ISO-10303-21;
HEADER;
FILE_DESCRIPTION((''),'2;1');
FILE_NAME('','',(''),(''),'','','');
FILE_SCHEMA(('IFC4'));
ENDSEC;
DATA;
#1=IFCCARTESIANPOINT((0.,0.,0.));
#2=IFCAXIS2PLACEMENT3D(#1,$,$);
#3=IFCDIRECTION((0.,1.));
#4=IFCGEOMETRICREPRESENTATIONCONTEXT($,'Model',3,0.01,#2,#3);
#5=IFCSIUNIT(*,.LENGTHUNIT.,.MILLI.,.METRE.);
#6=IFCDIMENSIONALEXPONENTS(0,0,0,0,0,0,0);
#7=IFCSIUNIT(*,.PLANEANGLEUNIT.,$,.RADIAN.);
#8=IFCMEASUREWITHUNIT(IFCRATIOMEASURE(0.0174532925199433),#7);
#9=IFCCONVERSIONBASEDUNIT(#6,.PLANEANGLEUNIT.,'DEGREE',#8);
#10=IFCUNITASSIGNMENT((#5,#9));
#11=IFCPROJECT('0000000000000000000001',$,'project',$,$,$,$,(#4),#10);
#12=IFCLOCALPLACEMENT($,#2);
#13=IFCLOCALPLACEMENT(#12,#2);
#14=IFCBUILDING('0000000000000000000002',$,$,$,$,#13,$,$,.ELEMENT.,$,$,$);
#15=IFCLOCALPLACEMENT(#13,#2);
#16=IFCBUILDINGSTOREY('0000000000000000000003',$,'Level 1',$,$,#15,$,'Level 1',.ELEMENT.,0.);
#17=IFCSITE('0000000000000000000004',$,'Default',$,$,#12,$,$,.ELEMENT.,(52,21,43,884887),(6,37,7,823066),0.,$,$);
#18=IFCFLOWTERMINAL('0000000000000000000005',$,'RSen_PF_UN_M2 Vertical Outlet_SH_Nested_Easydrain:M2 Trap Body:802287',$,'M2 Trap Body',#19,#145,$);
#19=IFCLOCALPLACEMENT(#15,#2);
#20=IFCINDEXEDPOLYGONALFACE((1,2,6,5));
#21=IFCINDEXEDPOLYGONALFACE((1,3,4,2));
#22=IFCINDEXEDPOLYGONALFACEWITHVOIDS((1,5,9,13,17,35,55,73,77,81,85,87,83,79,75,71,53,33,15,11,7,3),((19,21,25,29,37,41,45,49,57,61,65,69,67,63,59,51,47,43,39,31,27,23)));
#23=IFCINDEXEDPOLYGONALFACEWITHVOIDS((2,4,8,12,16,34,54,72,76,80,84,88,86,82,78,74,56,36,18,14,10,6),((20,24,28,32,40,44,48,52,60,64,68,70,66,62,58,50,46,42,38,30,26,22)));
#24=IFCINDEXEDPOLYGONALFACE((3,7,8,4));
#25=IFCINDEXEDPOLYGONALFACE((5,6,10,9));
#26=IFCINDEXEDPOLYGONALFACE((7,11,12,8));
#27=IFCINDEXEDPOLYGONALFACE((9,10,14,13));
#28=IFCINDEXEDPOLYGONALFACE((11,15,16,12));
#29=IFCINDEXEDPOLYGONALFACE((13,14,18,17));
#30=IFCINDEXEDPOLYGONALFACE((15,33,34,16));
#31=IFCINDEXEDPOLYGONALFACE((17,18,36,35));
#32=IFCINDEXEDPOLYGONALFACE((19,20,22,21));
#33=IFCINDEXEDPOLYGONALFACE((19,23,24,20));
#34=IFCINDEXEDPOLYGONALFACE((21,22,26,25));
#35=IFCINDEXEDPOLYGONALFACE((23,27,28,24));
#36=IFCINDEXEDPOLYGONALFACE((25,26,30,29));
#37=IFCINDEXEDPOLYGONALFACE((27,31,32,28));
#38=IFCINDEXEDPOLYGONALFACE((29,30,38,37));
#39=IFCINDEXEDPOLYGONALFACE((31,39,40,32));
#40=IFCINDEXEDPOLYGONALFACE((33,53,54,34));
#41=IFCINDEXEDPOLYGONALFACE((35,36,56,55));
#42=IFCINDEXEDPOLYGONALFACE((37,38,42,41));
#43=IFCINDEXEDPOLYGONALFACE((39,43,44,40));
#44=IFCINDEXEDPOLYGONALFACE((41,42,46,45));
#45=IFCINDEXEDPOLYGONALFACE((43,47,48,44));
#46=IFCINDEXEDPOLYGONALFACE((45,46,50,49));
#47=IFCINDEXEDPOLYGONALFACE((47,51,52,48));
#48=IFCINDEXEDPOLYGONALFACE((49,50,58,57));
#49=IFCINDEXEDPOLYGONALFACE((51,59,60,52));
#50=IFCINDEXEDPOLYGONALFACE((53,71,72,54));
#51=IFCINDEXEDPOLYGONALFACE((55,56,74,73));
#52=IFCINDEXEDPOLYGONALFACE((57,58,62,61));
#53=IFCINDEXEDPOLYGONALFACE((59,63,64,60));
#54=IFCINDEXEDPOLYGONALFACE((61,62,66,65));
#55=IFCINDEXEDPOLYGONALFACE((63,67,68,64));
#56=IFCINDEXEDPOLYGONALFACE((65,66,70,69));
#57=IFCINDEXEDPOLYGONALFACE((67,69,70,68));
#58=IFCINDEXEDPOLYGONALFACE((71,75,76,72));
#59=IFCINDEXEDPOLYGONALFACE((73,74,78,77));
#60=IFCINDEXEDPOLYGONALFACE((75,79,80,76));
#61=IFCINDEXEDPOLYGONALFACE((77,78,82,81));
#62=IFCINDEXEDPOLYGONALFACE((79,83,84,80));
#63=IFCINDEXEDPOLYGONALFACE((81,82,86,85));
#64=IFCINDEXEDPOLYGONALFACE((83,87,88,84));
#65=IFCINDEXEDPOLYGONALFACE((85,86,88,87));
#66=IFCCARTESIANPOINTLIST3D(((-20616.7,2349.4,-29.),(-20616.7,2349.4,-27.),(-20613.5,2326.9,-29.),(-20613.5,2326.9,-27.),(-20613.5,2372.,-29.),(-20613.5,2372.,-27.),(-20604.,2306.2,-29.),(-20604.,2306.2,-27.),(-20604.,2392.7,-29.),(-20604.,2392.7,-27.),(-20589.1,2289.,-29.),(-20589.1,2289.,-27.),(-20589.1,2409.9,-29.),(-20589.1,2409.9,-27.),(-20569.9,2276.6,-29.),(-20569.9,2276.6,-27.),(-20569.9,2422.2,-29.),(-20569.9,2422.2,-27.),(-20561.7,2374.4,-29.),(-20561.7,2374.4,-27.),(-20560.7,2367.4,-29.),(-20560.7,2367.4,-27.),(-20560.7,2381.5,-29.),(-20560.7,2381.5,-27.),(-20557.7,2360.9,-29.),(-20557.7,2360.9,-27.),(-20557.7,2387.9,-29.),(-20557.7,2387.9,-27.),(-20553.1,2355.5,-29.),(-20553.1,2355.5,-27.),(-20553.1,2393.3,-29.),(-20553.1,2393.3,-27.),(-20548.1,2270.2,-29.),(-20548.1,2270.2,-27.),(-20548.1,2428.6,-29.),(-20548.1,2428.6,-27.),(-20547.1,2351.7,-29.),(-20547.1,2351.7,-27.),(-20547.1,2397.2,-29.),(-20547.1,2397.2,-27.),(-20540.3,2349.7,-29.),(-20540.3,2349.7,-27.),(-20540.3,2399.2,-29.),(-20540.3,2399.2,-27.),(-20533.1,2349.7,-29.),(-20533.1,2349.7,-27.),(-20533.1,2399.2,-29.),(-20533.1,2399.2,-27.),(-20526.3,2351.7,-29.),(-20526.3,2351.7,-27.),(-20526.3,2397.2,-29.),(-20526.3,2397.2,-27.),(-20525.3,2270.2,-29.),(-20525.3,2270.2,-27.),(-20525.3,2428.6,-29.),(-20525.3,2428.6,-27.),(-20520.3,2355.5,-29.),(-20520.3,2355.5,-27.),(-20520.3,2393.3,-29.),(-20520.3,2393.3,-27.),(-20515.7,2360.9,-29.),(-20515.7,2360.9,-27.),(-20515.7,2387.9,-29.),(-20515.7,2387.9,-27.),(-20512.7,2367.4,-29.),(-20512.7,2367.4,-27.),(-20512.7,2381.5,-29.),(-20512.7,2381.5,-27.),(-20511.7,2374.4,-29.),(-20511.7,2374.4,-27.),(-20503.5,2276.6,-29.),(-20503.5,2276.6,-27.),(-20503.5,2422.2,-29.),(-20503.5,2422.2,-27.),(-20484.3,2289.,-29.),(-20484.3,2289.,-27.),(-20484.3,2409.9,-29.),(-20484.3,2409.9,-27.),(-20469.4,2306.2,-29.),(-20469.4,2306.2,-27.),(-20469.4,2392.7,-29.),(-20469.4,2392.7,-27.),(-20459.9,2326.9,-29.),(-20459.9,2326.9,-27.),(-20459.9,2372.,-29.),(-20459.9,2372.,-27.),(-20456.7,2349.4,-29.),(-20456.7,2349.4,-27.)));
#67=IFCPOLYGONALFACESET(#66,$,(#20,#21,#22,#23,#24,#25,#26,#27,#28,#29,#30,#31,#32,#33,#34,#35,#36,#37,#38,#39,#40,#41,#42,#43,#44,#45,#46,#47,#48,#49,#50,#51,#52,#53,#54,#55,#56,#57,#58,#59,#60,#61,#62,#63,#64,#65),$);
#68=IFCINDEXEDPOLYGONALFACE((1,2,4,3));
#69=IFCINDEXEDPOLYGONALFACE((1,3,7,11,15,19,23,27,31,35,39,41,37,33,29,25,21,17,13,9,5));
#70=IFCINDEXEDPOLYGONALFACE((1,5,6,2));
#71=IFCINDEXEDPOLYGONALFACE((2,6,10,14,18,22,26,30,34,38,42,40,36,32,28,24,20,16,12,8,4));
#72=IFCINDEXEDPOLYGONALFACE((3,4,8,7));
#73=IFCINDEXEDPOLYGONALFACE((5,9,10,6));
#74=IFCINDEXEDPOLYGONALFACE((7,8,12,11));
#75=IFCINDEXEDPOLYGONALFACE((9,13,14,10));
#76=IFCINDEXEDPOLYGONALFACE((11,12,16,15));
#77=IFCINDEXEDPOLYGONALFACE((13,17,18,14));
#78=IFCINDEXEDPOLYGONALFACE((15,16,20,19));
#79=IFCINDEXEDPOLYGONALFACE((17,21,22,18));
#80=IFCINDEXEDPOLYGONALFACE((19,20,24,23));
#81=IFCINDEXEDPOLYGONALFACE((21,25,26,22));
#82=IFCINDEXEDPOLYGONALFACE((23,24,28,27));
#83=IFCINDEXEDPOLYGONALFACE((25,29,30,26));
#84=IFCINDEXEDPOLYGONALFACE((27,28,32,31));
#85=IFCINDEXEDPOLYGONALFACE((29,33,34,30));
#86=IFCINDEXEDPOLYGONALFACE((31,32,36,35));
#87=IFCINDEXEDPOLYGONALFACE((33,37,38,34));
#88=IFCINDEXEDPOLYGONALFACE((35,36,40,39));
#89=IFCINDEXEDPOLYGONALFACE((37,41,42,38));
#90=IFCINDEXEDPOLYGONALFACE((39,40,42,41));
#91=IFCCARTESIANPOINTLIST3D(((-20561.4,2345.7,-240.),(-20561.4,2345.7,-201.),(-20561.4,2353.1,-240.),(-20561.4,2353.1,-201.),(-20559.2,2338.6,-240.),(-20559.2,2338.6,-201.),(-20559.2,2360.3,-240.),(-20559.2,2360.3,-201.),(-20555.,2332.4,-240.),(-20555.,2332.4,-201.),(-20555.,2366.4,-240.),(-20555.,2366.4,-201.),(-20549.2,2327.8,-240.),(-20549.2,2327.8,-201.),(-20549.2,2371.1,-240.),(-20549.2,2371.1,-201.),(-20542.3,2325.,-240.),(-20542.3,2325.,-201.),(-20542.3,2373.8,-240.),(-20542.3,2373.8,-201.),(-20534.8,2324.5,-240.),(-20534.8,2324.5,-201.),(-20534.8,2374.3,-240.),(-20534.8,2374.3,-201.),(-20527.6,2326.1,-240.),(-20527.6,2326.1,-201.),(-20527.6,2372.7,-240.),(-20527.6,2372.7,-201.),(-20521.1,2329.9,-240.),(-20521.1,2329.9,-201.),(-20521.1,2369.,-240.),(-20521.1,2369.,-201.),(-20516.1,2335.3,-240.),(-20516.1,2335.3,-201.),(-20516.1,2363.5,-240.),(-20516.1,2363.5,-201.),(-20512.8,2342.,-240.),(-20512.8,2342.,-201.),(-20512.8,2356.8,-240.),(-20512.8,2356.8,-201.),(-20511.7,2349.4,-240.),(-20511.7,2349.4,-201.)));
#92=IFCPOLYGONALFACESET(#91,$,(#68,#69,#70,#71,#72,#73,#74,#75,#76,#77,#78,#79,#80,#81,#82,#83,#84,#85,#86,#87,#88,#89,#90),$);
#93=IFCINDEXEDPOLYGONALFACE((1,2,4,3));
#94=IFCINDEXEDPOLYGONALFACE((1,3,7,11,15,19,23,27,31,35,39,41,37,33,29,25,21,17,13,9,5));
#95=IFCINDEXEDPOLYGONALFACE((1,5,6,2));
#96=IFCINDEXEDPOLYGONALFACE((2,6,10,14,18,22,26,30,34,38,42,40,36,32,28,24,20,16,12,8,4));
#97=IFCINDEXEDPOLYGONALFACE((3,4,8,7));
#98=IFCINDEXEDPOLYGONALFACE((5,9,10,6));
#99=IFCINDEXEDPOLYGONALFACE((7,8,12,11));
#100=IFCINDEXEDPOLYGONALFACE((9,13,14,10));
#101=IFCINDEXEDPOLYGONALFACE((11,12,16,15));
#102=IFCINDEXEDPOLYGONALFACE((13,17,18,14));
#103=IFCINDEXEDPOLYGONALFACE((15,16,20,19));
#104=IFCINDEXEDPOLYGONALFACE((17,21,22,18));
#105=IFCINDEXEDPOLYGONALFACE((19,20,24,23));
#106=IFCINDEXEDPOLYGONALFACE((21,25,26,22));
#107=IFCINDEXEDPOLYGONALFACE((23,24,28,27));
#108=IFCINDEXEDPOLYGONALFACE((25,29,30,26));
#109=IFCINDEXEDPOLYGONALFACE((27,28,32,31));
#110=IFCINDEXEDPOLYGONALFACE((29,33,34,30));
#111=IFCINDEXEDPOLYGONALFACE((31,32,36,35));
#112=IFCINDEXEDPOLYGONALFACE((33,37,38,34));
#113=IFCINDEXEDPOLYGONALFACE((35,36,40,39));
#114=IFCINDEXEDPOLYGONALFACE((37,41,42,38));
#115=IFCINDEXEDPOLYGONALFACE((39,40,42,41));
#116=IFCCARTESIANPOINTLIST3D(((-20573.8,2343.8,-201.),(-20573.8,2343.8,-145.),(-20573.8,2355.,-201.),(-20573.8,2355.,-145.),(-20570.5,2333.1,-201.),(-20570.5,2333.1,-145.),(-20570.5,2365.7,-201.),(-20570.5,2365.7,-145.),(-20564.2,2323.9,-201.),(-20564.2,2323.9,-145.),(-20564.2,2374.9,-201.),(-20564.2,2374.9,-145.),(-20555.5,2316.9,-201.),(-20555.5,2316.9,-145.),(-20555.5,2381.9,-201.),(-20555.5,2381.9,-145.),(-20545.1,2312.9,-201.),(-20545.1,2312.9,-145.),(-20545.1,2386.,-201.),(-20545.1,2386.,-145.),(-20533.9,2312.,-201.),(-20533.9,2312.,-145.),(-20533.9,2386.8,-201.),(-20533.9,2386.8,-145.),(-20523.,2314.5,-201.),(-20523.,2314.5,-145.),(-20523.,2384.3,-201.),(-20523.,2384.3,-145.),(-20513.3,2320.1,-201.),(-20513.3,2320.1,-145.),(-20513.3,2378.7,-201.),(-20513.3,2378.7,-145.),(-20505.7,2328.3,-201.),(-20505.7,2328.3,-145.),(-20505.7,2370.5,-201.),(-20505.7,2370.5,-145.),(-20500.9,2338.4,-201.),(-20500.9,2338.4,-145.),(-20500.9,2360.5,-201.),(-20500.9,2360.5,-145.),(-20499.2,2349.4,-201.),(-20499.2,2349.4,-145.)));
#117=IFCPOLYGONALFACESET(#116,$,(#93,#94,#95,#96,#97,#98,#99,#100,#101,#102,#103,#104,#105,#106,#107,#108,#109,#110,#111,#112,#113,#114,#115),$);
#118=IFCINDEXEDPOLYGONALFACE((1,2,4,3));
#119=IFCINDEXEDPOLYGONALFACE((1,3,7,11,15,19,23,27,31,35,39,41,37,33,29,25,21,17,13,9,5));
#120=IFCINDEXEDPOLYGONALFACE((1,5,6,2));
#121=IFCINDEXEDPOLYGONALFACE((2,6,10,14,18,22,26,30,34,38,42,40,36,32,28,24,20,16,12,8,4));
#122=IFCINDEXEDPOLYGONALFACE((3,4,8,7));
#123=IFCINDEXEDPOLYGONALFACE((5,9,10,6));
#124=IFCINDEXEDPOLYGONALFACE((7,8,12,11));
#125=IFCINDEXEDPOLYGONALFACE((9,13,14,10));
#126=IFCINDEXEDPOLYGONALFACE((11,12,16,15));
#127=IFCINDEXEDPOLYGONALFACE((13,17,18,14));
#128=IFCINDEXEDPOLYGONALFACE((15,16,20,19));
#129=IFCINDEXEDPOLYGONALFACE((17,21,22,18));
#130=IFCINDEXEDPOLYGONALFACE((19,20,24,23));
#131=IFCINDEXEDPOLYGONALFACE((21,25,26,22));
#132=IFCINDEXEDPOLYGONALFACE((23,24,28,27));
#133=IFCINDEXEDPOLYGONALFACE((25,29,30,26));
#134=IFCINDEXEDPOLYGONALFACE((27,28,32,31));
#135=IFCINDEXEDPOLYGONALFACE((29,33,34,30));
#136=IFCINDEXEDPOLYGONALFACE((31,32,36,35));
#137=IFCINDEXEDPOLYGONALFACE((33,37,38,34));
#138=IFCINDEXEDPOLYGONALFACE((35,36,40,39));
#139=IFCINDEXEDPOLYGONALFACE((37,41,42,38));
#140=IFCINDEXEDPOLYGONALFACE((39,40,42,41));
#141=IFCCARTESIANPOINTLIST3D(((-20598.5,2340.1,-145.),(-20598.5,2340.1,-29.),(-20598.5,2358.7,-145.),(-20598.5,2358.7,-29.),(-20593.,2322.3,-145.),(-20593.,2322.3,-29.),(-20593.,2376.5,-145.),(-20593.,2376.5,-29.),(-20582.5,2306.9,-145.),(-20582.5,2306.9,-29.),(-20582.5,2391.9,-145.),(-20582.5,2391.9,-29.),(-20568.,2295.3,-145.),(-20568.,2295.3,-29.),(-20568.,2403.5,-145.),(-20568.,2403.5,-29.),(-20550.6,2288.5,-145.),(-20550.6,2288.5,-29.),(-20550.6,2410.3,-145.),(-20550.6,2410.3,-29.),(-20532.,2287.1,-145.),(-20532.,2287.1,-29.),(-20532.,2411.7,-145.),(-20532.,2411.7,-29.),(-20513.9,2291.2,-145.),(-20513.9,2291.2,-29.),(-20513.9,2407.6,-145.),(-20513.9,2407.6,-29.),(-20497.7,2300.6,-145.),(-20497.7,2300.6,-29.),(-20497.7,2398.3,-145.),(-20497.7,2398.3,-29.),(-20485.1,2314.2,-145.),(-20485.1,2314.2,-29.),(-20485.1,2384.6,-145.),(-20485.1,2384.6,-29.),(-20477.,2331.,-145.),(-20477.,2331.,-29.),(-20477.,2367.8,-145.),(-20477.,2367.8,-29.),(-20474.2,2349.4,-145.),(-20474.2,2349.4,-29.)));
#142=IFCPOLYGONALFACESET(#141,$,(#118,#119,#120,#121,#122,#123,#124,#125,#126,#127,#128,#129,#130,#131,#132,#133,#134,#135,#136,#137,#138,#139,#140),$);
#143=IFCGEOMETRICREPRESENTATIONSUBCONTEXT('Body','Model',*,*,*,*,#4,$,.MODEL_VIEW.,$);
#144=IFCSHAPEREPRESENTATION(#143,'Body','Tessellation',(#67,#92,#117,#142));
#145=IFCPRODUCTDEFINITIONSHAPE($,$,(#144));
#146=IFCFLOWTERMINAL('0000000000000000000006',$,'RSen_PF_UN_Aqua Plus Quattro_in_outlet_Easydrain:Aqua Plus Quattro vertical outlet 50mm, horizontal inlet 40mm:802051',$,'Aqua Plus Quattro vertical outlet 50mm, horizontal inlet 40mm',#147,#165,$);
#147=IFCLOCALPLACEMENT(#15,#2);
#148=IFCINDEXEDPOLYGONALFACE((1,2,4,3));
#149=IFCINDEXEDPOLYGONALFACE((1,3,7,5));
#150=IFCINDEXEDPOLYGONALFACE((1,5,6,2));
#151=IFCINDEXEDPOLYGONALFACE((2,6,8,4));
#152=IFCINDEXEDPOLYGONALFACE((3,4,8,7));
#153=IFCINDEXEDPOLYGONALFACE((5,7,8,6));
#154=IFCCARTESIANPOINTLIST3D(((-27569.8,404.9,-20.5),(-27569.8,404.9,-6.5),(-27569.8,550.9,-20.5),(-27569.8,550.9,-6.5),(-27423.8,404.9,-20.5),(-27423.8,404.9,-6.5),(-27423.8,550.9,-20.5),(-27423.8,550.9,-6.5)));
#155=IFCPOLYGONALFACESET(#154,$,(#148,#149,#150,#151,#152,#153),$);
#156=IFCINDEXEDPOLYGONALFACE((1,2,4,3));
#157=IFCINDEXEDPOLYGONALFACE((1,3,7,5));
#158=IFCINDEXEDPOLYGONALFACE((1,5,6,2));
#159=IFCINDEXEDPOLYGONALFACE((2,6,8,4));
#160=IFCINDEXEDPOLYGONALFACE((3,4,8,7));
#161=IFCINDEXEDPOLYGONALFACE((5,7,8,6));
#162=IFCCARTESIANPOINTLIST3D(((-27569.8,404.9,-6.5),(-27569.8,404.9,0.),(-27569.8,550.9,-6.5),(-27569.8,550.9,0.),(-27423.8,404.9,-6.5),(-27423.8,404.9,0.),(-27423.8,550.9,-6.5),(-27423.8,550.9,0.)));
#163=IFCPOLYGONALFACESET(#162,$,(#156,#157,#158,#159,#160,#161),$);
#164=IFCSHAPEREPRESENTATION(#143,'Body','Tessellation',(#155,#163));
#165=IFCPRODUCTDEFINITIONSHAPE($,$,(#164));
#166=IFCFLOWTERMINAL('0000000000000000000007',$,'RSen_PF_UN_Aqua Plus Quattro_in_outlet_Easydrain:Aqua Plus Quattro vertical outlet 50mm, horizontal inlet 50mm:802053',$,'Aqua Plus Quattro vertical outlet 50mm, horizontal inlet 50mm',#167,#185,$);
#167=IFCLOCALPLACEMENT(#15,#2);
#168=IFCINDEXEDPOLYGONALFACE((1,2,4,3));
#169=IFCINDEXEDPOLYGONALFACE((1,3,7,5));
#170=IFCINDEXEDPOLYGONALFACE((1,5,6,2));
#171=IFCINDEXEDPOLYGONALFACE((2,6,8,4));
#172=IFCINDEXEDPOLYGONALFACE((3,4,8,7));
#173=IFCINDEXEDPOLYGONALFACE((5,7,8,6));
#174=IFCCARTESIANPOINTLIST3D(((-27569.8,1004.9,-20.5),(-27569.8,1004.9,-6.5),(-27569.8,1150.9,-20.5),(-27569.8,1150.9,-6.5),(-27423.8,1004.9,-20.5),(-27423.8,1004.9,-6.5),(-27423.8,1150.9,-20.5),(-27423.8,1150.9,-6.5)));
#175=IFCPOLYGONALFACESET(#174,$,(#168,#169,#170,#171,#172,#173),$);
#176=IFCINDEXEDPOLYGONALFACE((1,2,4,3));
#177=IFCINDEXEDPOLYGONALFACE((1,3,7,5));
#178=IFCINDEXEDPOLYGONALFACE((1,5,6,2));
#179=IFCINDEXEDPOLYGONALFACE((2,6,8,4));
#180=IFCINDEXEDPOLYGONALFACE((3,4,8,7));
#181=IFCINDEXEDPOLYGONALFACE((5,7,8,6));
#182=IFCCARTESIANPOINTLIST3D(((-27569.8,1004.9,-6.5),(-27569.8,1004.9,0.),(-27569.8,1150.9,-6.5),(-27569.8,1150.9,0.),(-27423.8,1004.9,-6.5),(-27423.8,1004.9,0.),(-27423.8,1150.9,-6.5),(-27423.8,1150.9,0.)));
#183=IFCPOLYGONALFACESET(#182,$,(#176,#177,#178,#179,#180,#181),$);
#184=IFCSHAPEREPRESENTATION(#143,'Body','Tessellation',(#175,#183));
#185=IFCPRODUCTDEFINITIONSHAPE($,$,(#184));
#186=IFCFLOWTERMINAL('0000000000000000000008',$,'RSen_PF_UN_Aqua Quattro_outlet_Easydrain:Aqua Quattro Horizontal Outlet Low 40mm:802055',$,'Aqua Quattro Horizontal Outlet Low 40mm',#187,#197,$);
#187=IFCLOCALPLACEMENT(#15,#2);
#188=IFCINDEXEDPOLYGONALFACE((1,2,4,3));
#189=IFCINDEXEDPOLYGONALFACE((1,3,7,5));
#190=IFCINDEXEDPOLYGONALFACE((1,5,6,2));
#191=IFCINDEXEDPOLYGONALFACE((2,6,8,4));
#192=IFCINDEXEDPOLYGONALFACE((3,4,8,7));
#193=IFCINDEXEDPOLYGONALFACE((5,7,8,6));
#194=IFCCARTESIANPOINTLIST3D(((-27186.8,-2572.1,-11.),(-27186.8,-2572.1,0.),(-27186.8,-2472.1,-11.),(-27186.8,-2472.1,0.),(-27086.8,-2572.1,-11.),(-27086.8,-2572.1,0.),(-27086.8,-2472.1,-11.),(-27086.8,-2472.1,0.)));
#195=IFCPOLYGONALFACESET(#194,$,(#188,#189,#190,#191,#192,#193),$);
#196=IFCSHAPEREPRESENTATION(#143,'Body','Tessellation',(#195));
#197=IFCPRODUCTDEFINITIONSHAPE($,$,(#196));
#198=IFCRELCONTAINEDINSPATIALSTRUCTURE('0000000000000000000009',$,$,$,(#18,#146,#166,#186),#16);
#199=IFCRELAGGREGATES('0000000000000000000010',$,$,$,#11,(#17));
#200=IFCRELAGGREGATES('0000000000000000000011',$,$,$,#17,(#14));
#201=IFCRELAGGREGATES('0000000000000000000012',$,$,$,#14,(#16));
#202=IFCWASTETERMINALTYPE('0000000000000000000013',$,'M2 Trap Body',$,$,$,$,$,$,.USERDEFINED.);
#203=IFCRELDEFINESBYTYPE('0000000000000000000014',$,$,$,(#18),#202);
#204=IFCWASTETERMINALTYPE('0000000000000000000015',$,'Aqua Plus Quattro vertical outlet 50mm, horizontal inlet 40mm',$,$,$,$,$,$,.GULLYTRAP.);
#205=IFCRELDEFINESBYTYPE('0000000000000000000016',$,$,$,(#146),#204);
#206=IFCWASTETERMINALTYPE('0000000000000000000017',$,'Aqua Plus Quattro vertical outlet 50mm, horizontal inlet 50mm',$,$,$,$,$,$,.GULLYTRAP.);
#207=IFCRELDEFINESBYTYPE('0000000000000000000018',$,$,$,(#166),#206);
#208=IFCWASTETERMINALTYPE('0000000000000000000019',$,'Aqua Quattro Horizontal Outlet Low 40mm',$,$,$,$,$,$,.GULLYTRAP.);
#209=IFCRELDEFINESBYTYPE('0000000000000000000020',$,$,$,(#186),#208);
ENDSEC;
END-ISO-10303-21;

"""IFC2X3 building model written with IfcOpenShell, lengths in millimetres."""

from ifc_helpers import new_model, entity, si_unit, converted_unit, direction, frame, frame_2d, origin, origin_2d_with_axis, place, context, subcontext, project, spatial, circle_curve, parameter, trimmed, segment, composite_curve, rectangle, circle, outline, extrude, source, transform, mapped, type_object, type_shapes, element, save


model = new_model("IFC2X3")

# Units and contexts
model_context = context("Model", 3, precision=0.01, world=origin(), true_north=direction((0.0, 1.0)))
body_context = subcontext(model_context, "Body", "Model", "MODEL_VIEW")
ifc_project = project(units=[si_unit("LENGTHUNIT", "METRE", prefix="MILLI"), converted_unit("PLANEANGLEUNIT", "DEGREE", entity("IfcRatioMeasure", 0.0174532925199433), si_unit("PLANEANGLEUNIT", "RADIAN"), dimensions=[0, 0, 0, 0, 0, 0, 0])], contexts=[model_context])

# Site, building, storey
site_placement = place(None, origin())
site = spatial("IfcSite", under=ifc_project, at=site_placement, Name="Default", CompositionType="ELEMENT", RefLatitude=(52, 21, 43, 884887), RefLongitude=(6, 37, 7, 823066), RefElevation=0.0)
building_placement = place(site_placement, origin())
building = spatial("IfcBuilding", under=site, at=building_placement, CompositionType="ELEMENT")
storey_placement = place(building_placement, origin())
storey = spatial("IfcBuildingStorey", under=building, at=storey_placement, Name="Level 1", LongName="Level 1", CompositionType="ELEMENT", Elevation=0.0)

# Flow terminals
waste_terminal_type_1 = type_object("IfcWasteTerminalType", Name="M2 Trap Body", PredefinedType="USERDEFINED")
shared_shape_1 = source(origin(), body_context, "Body", "SweptSolid", [
    extrude(outline(composite_curve([segment(trimmed(circle_curve(origin_2d_with_axis(), 80.0), [parameter(0.0)], [parameter(180.0)], True, "PARAMETER"), True, "CONTINUOUS"), segment(trimmed(circle_curve(origin_2d_with_axis(), 80.0), [parameter(180.0)], [parameter(360.0)], True, "PARAMETER"), True, "CONTINUOUS")], self_intersect=False), holes=[composite_curve([segment(trimmed(circle_curve(frame_2d((0.0, 25.0), x_axis=(1.0, 0.0)), 25.0), [parameter(180.0)], [parameter(360.0)], True, "PARAMETER"), False, "CONTINUOUS"), segment(trimmed(circle_curve(frame_2d((0.0, 25.0), x_axis=(1.0, 0.0)), 25.0), [parameter(0.0)], [parameter(180.0)], True, "PARAMETER"), False, "CONTINUOUS")], self_intersect=False)]), frame((0.0, -25.0, -2.0)), (0.0, 0.0, 1.0), 2.0),
    extrude(circle(Radius=25.0, at=frame_2d((0.0, 0.0), x_axis=(1.0, 0.0))), frame((0.0, -25.0, -213.0)), (0.0, 0.0, 1.0), 39.0),
    extrude(circle(Radius=37.5, at=frame_2d((0.0, 0.0), x_axis=(1.0, 0.0))), frame((0.0, -25.0, -174.0)), (0.0, 0.0, 1.0), 56.0),
    extrude(circle(Radius=62.5, at=frame_2d((0.0, 0.0), x_axis=(1.0, 0.0))), frame((0.0, -25.0, -118.0)), (0.0, 0.0, 1.0), 116.0),
])
type_shapes(waste_terminal_type_1, [shared_shape_1])
for number, where, name in (
    (1, (-20536.7, 2374.4, -27.0), "RSen_PF_UN_M2 Vertical Outlet_SH_Nested_Easydrain:M2 Trap Body:802287"),
):
    element("IfcFlowTerminal", number, at=place(storey_placement, frame(where)), inside=storey, type_object=waste_terminal_type_1, Name=name, ObjectType="M2 Trap Body", context=body_context, shape_type="MappedRepresentation", body=[
        mapped(shared_shape_1, transform((0.0, 0.0, 0.0), scale=1.0)),
    ])
waste_terminal_type_2 = type_object("IfcWasteTerminalType", Name="Aqua Plus Quattro vertical outlet 50mm, horizontal inlet 40mm", PredefinedType="GULLYTRAP")
shared_shape_2 = source(origin(), body_context, "Body", "SweptSolid", [
    extrude(rectangle(XDim=146.0, YDim=146.0, at=origin_2d_with_axis()), frame((0.0, 0.0, -20.5), z_axis=(0.0, 0.0, 1.0), x_axis=(-1.0, 0.0, 0.0)), (0.0, 0.0, 1.0), 14.0),
    extrude(rectangle(XDim=146.0, YDim=146.0, at=origin_2d_with_axis()), frame((0.0, 0.0, -6.5), z_axis=(0.0, 0.0, 1.0), x_axis=(-1.0, 0.0, 0.0)), (0.0, 0.0, 1.0), 6.5),
])
type_shapes(waste_terminal_type_2, [shared_shape_2])
flow_terminal_1_placement = place(storey_placement, frame((-27496.8, 477.9, 0.0)))
element("IfcFlowTerminal", 2, at=flow_terminal_1_placement, inside=storey, type_object=waste_terminal_type_2, Name="RSen_PF_UN_Aqua Plus Quattro_in_outlet_Easydrain:Aqua Plus Quattro vertical outlet 50mm, horizontal inlet 40mm:802051", ObjectType="Aqua Plus Quattro vertical outlet 50mm, horizontal inlet 40mm", context=body_context, shape_type="MappedRepresentation", body=[
    mapped(shared_shape_2, transform((0.0, 0.0, 0.0), scale=1.0)),
])
waste_terminal_type_3 = type_object("IfcWasteTerminalType", Name="Aqua Plus Quattro vertical outlet 50mm, horizontal inlet 50mm", PredefinedType="GULLYTRAP")
shared_shape_3 = source(origin(), body_context, "Body", "SweptSolid", [
    extrude(rectangle(XDim=146.0, YDim=146.0, at=origin_2d_with_axis()), frame((0.0, 0.0, -20.5), z_axis=(0.0, 0.0, 1.0), x_axis=(-1.0, 0.0, 0.0)), (0.0, 0.0, 1.0), 14.0),
    extrude(rectangle(XDim=146.0, YDim=146.0, at=origin_2d_with_axis()), frame((0.0, 0.0, -6.5), z_axis=(0.0, 0.0, 1.0), x_axis=(-1.0, 0.0, 0.0)), (0.0, 0.0, 1.0), 6.5),
])
type_shapes(waste_terminal_type_3, [shared_shape_3])
flow_terminal_2_placement = place(storey_placement, frame((-27496.8, 1077.9, 0.0)))
element("IfcFlowTerminal", 3, at=flow_terminal_2_placement, inside=storey, type_object=waste_terminal_type_3, Name="RSen_PF_UN_Aqua Plus Quattro_in_outlet_Easydrain:Aqua Plus Quattro vertical outlet 50mm, horizontal inlet 50mm:802053", ObjectType="Aqua Plus Quattro vertical outlet 50mm, horizontal inlet 50mm", context=body_context, shape_type="MappedRepresentation", body=[
    mapped(shared_shape_3, transform((0.0, 0.0, 0.0), scale=1.0)),
])
waste_terminal_type_4 = type_object("IfcWasteTerminalType", Name="Aqua Quattro Horizontal Outlet Low 40mm", PredefinedType="GULLYTRAP")
shared_shape_4 = source(origin(), body_context, "Body", "SweptSolid", [
    extrude(rectangle(XDim=100.0, YDim=100.0, at=origin_2d_with_axis()), frame((0.0, 0.0, -11.0), z_axis=(0.0, 0.0, 1.0), x_axis=(-1.0, 0.0, 0.0)), (0.0, 0.0, 1.0), 11.0),
])
type_shapes(waste_terminal_type_4, [shared_shape_4])
flow_terminal_3_placement = place(storey_placement, frame((-27136.8, -2522.1, 0.0)))
element("IfcFlowTerminal", 4, at=flow_terminal_3_placement, inside=storey, type_object=waste_terminal_type_4, Name="RSen_PF_UN_Aqua Quattro_outlet_Easydrain:Aqua Quattro Horizontal Outlet Low 40mm:802055", ObjectType="Aqua Quattro Horizontal Outlet Low 40mm", context=body_context, shape_type="MappedRepresentation", body=[
    mapped(shared_shape_4, transform((0.0, 0.0, 0.0), scale=1.0)),
])

save(model, "model.ifc")
